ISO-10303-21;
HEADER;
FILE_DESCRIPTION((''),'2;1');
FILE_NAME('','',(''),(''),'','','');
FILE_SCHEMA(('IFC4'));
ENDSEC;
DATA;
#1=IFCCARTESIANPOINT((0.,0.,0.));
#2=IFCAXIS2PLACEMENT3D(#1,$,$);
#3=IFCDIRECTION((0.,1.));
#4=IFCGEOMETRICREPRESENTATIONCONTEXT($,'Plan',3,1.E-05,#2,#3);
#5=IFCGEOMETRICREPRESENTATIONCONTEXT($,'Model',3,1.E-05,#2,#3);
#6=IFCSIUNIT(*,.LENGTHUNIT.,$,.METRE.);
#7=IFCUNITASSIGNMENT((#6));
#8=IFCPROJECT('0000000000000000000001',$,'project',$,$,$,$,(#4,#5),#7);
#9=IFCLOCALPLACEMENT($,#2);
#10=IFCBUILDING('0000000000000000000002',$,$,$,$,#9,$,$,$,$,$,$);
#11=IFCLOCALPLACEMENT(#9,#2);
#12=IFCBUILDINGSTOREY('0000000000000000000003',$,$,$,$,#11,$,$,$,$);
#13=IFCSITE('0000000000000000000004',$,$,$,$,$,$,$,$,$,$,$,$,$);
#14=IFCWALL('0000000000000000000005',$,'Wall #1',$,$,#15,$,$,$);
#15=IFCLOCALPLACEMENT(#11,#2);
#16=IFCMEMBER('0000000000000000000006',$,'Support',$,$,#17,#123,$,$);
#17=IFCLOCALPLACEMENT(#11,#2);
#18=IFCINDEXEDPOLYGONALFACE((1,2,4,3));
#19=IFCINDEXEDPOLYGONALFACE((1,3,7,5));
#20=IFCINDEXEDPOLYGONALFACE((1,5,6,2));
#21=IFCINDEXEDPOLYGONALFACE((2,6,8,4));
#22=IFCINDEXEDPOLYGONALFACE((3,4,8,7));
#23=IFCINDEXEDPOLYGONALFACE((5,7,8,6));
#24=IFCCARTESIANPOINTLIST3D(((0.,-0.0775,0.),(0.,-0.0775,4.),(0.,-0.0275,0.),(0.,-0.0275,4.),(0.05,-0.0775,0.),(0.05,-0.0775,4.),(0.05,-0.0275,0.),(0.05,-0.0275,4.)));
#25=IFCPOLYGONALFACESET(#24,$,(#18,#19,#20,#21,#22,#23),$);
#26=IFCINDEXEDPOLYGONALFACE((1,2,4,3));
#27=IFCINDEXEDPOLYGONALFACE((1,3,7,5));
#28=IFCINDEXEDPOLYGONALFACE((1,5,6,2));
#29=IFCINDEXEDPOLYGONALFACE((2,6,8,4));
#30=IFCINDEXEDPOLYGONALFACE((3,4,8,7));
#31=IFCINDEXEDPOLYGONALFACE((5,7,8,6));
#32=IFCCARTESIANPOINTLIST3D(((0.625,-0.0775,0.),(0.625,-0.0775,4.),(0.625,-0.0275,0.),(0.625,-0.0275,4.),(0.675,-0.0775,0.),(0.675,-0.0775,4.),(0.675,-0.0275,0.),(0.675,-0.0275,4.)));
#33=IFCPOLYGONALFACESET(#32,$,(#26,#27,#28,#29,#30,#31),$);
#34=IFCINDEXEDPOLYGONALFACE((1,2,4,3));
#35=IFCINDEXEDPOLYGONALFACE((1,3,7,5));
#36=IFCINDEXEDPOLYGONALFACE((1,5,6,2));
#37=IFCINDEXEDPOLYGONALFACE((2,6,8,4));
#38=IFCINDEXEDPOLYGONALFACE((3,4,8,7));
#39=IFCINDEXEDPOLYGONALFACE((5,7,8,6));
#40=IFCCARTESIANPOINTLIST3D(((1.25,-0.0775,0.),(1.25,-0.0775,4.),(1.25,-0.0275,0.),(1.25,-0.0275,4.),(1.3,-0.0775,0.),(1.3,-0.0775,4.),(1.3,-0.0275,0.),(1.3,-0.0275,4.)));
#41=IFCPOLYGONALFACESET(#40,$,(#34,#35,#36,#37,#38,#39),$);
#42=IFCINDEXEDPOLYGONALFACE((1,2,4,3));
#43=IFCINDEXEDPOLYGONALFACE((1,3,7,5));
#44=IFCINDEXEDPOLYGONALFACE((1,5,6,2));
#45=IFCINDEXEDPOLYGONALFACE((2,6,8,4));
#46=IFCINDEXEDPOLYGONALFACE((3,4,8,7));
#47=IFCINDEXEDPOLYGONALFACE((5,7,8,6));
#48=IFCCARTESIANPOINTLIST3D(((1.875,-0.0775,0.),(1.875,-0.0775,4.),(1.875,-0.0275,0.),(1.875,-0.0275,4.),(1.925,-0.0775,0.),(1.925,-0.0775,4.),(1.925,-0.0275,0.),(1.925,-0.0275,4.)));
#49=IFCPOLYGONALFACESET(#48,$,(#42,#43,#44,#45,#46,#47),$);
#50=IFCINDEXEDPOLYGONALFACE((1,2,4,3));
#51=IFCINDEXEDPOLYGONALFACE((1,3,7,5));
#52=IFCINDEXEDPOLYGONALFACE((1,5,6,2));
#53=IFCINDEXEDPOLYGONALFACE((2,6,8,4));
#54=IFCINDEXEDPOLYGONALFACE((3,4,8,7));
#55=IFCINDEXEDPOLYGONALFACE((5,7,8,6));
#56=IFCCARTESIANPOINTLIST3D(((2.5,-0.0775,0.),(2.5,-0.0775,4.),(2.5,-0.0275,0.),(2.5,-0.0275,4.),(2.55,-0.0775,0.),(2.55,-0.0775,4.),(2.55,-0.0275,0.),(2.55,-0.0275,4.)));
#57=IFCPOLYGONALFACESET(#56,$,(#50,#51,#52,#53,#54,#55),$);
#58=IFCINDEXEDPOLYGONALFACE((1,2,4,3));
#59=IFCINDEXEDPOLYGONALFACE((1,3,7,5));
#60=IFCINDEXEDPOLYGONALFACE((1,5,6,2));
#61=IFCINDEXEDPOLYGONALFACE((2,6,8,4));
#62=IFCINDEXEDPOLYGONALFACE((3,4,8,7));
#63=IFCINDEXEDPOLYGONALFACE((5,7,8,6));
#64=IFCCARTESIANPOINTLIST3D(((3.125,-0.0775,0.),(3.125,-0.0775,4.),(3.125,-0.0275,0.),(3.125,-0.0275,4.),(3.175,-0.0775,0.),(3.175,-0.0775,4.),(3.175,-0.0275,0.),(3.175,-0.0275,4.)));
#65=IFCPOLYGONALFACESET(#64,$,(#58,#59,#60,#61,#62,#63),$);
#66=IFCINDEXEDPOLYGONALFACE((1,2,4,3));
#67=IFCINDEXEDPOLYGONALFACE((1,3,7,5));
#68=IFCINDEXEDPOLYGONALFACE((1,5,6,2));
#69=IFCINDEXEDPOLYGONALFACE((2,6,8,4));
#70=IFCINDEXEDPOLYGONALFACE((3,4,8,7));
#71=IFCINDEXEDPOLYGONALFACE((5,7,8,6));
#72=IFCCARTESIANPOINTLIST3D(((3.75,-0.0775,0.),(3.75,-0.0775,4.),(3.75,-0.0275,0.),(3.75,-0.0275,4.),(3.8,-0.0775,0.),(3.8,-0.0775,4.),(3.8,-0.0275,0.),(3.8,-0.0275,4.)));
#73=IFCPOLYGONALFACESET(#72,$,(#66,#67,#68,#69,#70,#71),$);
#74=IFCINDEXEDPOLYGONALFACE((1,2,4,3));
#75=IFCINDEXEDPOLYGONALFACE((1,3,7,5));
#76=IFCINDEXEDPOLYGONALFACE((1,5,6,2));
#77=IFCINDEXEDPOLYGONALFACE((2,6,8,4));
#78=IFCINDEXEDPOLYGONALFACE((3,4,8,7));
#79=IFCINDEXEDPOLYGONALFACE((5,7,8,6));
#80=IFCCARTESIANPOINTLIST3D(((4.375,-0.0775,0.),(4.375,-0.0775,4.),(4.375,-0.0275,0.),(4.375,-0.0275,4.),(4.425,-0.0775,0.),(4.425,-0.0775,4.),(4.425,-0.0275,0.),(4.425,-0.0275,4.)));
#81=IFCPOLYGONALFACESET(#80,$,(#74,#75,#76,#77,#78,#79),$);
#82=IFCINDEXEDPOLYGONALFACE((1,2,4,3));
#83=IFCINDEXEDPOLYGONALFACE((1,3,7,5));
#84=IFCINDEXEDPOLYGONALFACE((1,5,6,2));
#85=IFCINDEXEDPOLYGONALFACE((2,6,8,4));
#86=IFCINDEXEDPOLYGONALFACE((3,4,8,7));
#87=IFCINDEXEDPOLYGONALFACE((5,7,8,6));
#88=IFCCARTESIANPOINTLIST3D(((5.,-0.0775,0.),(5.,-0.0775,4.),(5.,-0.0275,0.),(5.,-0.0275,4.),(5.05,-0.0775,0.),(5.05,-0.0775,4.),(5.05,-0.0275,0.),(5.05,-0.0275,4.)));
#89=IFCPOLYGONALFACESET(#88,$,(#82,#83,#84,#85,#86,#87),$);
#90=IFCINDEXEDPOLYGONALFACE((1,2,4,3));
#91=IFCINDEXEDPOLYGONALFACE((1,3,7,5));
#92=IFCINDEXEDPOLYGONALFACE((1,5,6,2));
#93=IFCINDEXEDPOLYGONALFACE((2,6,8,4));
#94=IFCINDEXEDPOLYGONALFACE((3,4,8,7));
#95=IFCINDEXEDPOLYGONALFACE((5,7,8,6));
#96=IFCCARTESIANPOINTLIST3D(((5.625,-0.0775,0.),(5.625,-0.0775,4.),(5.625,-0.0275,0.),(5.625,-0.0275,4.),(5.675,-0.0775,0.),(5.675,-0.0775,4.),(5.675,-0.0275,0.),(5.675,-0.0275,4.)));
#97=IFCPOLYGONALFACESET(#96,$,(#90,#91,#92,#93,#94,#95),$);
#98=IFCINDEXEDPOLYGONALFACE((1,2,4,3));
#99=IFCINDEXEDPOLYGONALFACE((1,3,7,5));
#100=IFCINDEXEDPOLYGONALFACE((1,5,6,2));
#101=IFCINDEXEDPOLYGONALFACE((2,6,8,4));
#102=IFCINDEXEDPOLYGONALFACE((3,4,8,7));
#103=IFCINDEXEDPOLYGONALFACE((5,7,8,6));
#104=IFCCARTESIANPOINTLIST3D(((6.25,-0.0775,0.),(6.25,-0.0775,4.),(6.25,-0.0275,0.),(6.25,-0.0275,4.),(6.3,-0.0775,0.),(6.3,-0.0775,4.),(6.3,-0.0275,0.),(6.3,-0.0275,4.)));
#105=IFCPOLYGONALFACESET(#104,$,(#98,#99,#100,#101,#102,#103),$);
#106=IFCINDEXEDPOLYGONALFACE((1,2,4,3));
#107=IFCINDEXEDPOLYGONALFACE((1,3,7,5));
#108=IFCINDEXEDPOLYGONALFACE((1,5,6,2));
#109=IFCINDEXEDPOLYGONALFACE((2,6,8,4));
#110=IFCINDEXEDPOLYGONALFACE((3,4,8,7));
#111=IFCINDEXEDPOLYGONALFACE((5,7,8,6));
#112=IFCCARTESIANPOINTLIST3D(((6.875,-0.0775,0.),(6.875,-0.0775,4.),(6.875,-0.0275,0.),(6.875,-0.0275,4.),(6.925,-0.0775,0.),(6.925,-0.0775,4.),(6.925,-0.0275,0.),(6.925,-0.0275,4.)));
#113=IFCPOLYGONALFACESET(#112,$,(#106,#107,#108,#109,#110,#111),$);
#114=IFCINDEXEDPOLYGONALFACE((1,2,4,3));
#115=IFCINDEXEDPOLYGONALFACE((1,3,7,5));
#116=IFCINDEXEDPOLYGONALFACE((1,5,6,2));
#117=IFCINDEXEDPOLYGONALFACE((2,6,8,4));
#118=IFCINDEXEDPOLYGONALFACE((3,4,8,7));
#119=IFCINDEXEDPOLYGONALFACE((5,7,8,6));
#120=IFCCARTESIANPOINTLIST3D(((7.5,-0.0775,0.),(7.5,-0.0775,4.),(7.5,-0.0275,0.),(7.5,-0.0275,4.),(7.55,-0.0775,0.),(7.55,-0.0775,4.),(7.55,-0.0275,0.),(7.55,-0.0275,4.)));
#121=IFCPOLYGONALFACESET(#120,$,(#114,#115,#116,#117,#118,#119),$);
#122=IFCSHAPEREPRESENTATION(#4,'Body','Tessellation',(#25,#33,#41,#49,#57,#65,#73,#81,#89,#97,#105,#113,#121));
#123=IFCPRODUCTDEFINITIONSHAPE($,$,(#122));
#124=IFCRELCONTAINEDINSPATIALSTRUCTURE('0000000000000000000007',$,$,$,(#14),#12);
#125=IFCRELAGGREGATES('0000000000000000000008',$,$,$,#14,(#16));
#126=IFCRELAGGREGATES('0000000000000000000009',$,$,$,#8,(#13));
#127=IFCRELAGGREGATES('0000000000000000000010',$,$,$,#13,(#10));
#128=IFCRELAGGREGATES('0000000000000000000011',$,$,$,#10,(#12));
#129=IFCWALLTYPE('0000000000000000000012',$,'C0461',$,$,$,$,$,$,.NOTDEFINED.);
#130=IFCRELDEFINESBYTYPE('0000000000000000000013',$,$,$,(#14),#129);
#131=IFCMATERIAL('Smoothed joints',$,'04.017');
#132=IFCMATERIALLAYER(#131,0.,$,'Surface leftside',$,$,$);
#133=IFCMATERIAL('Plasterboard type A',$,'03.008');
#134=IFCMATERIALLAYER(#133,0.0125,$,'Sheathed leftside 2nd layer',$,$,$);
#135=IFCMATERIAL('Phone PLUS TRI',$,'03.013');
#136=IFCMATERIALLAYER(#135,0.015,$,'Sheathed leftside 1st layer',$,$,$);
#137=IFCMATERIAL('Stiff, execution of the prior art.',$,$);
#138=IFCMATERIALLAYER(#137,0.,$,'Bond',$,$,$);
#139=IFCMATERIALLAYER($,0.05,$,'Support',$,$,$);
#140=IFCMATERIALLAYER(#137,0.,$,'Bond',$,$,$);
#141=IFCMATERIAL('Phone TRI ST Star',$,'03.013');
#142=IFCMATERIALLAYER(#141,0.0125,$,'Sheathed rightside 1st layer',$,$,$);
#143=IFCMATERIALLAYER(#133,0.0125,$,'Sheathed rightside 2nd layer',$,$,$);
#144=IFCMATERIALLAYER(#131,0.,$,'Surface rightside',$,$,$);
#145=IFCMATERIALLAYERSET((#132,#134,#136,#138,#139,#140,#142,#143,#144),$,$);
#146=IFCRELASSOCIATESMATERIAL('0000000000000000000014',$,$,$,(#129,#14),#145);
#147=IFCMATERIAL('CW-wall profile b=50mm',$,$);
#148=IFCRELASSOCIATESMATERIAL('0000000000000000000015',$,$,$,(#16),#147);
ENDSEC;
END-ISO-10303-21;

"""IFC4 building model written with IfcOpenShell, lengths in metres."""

from ifc_helpers import new_model, si_unit, direction, frame, frame_2d, origin, place, context, project, spatial, rectangle, extrude, material, layer, layer_set, type_object, element, aggregate, save


model = new_model("IFC4")

# Units and contexts
plan_context = context("Plan", 3, precision=1e-05, world=origin(), true_north=direction((0.0, 1.0)))
model_context = context("Model", 3, precision=1e-05, world=origin(), true_north=direction((0.0, 1.0)))
ifc_project = project(units=[si_unit("LENGTHUNIT", "METRE")], contexts=[plan_context, model_context])

# Site, building, storey
site = spatial("IfcSite", under=ifc_project)
building_placement = place(None, origin())
building = spatial("IfcBuilding", under=site, at=building_placement)
storey_placement = place(building_placement, origin())
storey = spatial("IfcBuildingStorey", under=building, at=storey_placement)

# Wall, member
ifc_material_1 = material(Name="Smoothed joints", Category="04.017")
ifc_layer_1 = layer(ifc_material_1, 0.0, Name="Surface leftside")
ifc_material_2 = material(Name="Plasterboard type A", Category="03.008")
ifc_layer_2 = layer(ifc_material_2, 0.0125, Name="Sheathed leftside 2nd layer")
ifc_material_3 = material(Name="Phone PLUS TRI", Category="03.013")
ifc_layer_3 = layer(ifc_material_3, 0.015, Name="Sheathed leftside 1st layer")
ifc_material_4 = material(Name="Stiff, execution of the prior art.")
ifc_layer_4 = layer(ifc_material_4, 0.0, Name="Bond")
ifc_layer_5 = layer(None, 0.05, Name="Support")
ifc_layer_6 = layer(ifc_material_4, 0.0, Name="Bond")
ifc_material_5 = material(Name="Phone TRI ST Star", Category="03.013")
ifc_layer_7 = layer(ifc_material_5, 0.0125, Name="Sheathed rightside 1st layer")
ifc_layer_8 = layer(ifc_material_2, 0.0125, Name="Sheathed rightside 2nd layer")
ifc_layer_9 = layer(ifc_material_1, 0.0, Name="Surface rightside")
ifc_layer_set = layer_set([ifc_layer_1, ifc_layer_2, ifc_layer_3, ifc_layer_4, ifc_layer_5, ifc_layer_6, ifc_layer_7, ifc_layer_8, ifc_layer_9])
wall_type = type_object("IfcWallType", Name="C0461", PredefinedType="NOTDEFINED", material=ifc_layer_set)
wall_placement = place(None, frame((0.0, 0.0, 0.0), z_axis=(0.0, -1.0, 0.0), x_axis=(1.0, 0.0, 0.0)))
wall = element("IfcWall", 1, at=wall_placement, inside=storey, type_object=wall_type, material=ifc_layer_set, Name="Wall #1")
ifc_material_6 = material(Name="CW-wall profile b=50mm")
member_1_placement = place(wall_placement, origin())
member_1 = element("IfcMember", 2, at=member_1_placement, material=ifc_material_6, Name="Support", context=plan_context, shape_type="SweptSolid", body=[
    extrude(rectangle(XDim=0.05, YDim=0.05, at=frame_2d((0.025, 0.025), x_axis=(1.0, 0.0))), frame((0.0, 4.0, 0.0275), z_axis=(0.0, -1.0, 0.0), x_axis=(1.0, 0.0, 0.0)), (0.0, 0.0, 1.0), 4.0),
    extrude(rectangle(XDim=0.05, YDim=0.05, at=frame_2d((0.025, 0.025), x_axis=(1.0, 0.0))), frame((0.625, 4.0, 0.0275), z_axis=(0.0, -1.0, 0.0), x_axis=(1.0, 0.0, 0.0)), (0.0, 0.0, 1.0), 4.0),
    extrude(rectangle(XDim=0.05, YDim=0.05, at=frame_2d((0.025, 0.025), x_axis=(1.0, 0.0))), frame((1.25, 4.0, 0.0275), z_axis=(0.0, -1.0, 0.0), x_axis=(1.0, 0.0, 0.0)), (0.0, 0.0, 1.0), 4.0),
    extrude(rectangle(XDim=0.05, YDim=0.05, at=frame_2d((0.025, 0.025), x_axis=(1.0, 0.0))), frame((1.875, 4.0, 0.0275), z_axis=(0.0, -1.0, 0.0), x_axis=(1.0, 0.0, 0.0)), (0.0, 0.0, 1.0), 4.0),
    extrude(rectangle(XDim=0.05, YDim=0.05, at=frame_2d((0.025, 0.025), x_axis=(1.0, 0.0))), frame((2.5, 4.0, 0.0275), z_axis=(0.0, -1.0, 0.0), x_axis=(1.0, 0.0, 0.0)), (0.0, 0.0, 1.0), 4.0),
    extrude(rectangle(XDim=0.05, YDim=0.05, at=frame_2d((0.025, 0.025), x_axis=(1.0, 0.0))), frame((3.125, 4.0, 0.0275), z_axis=(0.0, -1.0, 0.0), x_axis=(1.0, 0.0, 0.0)), (0.0, 0.0, 1.0), 4.0),
    extrude(rectangle(XDim=0.05, YDim=0.05, at=frame_2d((0.025, 0.025), x_axis=(1.0, 0.0))), frame((3.75, 4.0, 0.0275), z_axis=(0.0, -1.0, 0.0), x_axis=(1.0, 0.0, 0.0)), (0.0, 0.0, 1.0), 4.0),
    extrude(rectangle(XDim=0.05, YDim=0.05, at=frame_2d((0.025, 0.025), x_axis=(1.0, 0.0))), frame((4.375, 4.0, 0.0275), z_axis=(0.0, -1.0, 0.0), x_axis=(1.0, 0.0, 0.0)), (0.0, 0.0, 1.0), 4.0),
    extrude(rectangle(XDim=0.05, YDim=0.05, at=frame_2d((0.025, 0.025), x_axis=(1.0, 0.0))), frame((5.0, 4.0, 0.0275), z_axis=(0.0, -1.0, 0.0), x_axis=(1.0, 0.0, 0.0)), (0.0, 0.0, 1.0), 4.0),
    extrude(rectangle(XDim=0.05, YDim=0.05, at=frame_2d((0.025, 0.025), x_axis=(1.0, 0.0))), frame((5.625, 4.0, 0.0275), z_axis=(0.0, -1.0, 0.0), x_axis=(1.0, 0.0, 0.0)), (0.0, 0.0, 1.0), 4.0),
    extrude(rectangle(XDim=0.05, YDim=0.05, at=frame_2d((0.025, 0.025), x_axis=(1.0, 0.0))), frame((6.25, 4.0, 0.0275), z_axis=(0.0, -1.0, 0.0), x_axis=(1.0, 0.0, 0.0)), (0.0, 0.0, 1.0), 4.0),
    extrude(rectangle(XDim=0.05, YDim=0.05, at=frame_2d((0.025, 0.025), x_axis=(1.0, 0.0))), frame((6.875, 4.0, 0.0275), z_axis=(0.0, -1.0, 0.0), x_axis=(1.0, 0.0, 0.0)), (0.0, 0.0, 1.0), 4.0),
    extrude(rectangle(XDim=0.05, YDim=0.05, at=frame_2d((0.025, 0.025), x_axis=(1.0, 0.0))), frame((7.5, 4.0, 0.0275), z_axis=(0.0, -1.0, 0.0), x_axis=(1.0, 0.0, 0.0)), (0.0, 0.0, 1.0), 4.0),
])
aggregate(wall, [member_1])

save(model, "model.ifc")
